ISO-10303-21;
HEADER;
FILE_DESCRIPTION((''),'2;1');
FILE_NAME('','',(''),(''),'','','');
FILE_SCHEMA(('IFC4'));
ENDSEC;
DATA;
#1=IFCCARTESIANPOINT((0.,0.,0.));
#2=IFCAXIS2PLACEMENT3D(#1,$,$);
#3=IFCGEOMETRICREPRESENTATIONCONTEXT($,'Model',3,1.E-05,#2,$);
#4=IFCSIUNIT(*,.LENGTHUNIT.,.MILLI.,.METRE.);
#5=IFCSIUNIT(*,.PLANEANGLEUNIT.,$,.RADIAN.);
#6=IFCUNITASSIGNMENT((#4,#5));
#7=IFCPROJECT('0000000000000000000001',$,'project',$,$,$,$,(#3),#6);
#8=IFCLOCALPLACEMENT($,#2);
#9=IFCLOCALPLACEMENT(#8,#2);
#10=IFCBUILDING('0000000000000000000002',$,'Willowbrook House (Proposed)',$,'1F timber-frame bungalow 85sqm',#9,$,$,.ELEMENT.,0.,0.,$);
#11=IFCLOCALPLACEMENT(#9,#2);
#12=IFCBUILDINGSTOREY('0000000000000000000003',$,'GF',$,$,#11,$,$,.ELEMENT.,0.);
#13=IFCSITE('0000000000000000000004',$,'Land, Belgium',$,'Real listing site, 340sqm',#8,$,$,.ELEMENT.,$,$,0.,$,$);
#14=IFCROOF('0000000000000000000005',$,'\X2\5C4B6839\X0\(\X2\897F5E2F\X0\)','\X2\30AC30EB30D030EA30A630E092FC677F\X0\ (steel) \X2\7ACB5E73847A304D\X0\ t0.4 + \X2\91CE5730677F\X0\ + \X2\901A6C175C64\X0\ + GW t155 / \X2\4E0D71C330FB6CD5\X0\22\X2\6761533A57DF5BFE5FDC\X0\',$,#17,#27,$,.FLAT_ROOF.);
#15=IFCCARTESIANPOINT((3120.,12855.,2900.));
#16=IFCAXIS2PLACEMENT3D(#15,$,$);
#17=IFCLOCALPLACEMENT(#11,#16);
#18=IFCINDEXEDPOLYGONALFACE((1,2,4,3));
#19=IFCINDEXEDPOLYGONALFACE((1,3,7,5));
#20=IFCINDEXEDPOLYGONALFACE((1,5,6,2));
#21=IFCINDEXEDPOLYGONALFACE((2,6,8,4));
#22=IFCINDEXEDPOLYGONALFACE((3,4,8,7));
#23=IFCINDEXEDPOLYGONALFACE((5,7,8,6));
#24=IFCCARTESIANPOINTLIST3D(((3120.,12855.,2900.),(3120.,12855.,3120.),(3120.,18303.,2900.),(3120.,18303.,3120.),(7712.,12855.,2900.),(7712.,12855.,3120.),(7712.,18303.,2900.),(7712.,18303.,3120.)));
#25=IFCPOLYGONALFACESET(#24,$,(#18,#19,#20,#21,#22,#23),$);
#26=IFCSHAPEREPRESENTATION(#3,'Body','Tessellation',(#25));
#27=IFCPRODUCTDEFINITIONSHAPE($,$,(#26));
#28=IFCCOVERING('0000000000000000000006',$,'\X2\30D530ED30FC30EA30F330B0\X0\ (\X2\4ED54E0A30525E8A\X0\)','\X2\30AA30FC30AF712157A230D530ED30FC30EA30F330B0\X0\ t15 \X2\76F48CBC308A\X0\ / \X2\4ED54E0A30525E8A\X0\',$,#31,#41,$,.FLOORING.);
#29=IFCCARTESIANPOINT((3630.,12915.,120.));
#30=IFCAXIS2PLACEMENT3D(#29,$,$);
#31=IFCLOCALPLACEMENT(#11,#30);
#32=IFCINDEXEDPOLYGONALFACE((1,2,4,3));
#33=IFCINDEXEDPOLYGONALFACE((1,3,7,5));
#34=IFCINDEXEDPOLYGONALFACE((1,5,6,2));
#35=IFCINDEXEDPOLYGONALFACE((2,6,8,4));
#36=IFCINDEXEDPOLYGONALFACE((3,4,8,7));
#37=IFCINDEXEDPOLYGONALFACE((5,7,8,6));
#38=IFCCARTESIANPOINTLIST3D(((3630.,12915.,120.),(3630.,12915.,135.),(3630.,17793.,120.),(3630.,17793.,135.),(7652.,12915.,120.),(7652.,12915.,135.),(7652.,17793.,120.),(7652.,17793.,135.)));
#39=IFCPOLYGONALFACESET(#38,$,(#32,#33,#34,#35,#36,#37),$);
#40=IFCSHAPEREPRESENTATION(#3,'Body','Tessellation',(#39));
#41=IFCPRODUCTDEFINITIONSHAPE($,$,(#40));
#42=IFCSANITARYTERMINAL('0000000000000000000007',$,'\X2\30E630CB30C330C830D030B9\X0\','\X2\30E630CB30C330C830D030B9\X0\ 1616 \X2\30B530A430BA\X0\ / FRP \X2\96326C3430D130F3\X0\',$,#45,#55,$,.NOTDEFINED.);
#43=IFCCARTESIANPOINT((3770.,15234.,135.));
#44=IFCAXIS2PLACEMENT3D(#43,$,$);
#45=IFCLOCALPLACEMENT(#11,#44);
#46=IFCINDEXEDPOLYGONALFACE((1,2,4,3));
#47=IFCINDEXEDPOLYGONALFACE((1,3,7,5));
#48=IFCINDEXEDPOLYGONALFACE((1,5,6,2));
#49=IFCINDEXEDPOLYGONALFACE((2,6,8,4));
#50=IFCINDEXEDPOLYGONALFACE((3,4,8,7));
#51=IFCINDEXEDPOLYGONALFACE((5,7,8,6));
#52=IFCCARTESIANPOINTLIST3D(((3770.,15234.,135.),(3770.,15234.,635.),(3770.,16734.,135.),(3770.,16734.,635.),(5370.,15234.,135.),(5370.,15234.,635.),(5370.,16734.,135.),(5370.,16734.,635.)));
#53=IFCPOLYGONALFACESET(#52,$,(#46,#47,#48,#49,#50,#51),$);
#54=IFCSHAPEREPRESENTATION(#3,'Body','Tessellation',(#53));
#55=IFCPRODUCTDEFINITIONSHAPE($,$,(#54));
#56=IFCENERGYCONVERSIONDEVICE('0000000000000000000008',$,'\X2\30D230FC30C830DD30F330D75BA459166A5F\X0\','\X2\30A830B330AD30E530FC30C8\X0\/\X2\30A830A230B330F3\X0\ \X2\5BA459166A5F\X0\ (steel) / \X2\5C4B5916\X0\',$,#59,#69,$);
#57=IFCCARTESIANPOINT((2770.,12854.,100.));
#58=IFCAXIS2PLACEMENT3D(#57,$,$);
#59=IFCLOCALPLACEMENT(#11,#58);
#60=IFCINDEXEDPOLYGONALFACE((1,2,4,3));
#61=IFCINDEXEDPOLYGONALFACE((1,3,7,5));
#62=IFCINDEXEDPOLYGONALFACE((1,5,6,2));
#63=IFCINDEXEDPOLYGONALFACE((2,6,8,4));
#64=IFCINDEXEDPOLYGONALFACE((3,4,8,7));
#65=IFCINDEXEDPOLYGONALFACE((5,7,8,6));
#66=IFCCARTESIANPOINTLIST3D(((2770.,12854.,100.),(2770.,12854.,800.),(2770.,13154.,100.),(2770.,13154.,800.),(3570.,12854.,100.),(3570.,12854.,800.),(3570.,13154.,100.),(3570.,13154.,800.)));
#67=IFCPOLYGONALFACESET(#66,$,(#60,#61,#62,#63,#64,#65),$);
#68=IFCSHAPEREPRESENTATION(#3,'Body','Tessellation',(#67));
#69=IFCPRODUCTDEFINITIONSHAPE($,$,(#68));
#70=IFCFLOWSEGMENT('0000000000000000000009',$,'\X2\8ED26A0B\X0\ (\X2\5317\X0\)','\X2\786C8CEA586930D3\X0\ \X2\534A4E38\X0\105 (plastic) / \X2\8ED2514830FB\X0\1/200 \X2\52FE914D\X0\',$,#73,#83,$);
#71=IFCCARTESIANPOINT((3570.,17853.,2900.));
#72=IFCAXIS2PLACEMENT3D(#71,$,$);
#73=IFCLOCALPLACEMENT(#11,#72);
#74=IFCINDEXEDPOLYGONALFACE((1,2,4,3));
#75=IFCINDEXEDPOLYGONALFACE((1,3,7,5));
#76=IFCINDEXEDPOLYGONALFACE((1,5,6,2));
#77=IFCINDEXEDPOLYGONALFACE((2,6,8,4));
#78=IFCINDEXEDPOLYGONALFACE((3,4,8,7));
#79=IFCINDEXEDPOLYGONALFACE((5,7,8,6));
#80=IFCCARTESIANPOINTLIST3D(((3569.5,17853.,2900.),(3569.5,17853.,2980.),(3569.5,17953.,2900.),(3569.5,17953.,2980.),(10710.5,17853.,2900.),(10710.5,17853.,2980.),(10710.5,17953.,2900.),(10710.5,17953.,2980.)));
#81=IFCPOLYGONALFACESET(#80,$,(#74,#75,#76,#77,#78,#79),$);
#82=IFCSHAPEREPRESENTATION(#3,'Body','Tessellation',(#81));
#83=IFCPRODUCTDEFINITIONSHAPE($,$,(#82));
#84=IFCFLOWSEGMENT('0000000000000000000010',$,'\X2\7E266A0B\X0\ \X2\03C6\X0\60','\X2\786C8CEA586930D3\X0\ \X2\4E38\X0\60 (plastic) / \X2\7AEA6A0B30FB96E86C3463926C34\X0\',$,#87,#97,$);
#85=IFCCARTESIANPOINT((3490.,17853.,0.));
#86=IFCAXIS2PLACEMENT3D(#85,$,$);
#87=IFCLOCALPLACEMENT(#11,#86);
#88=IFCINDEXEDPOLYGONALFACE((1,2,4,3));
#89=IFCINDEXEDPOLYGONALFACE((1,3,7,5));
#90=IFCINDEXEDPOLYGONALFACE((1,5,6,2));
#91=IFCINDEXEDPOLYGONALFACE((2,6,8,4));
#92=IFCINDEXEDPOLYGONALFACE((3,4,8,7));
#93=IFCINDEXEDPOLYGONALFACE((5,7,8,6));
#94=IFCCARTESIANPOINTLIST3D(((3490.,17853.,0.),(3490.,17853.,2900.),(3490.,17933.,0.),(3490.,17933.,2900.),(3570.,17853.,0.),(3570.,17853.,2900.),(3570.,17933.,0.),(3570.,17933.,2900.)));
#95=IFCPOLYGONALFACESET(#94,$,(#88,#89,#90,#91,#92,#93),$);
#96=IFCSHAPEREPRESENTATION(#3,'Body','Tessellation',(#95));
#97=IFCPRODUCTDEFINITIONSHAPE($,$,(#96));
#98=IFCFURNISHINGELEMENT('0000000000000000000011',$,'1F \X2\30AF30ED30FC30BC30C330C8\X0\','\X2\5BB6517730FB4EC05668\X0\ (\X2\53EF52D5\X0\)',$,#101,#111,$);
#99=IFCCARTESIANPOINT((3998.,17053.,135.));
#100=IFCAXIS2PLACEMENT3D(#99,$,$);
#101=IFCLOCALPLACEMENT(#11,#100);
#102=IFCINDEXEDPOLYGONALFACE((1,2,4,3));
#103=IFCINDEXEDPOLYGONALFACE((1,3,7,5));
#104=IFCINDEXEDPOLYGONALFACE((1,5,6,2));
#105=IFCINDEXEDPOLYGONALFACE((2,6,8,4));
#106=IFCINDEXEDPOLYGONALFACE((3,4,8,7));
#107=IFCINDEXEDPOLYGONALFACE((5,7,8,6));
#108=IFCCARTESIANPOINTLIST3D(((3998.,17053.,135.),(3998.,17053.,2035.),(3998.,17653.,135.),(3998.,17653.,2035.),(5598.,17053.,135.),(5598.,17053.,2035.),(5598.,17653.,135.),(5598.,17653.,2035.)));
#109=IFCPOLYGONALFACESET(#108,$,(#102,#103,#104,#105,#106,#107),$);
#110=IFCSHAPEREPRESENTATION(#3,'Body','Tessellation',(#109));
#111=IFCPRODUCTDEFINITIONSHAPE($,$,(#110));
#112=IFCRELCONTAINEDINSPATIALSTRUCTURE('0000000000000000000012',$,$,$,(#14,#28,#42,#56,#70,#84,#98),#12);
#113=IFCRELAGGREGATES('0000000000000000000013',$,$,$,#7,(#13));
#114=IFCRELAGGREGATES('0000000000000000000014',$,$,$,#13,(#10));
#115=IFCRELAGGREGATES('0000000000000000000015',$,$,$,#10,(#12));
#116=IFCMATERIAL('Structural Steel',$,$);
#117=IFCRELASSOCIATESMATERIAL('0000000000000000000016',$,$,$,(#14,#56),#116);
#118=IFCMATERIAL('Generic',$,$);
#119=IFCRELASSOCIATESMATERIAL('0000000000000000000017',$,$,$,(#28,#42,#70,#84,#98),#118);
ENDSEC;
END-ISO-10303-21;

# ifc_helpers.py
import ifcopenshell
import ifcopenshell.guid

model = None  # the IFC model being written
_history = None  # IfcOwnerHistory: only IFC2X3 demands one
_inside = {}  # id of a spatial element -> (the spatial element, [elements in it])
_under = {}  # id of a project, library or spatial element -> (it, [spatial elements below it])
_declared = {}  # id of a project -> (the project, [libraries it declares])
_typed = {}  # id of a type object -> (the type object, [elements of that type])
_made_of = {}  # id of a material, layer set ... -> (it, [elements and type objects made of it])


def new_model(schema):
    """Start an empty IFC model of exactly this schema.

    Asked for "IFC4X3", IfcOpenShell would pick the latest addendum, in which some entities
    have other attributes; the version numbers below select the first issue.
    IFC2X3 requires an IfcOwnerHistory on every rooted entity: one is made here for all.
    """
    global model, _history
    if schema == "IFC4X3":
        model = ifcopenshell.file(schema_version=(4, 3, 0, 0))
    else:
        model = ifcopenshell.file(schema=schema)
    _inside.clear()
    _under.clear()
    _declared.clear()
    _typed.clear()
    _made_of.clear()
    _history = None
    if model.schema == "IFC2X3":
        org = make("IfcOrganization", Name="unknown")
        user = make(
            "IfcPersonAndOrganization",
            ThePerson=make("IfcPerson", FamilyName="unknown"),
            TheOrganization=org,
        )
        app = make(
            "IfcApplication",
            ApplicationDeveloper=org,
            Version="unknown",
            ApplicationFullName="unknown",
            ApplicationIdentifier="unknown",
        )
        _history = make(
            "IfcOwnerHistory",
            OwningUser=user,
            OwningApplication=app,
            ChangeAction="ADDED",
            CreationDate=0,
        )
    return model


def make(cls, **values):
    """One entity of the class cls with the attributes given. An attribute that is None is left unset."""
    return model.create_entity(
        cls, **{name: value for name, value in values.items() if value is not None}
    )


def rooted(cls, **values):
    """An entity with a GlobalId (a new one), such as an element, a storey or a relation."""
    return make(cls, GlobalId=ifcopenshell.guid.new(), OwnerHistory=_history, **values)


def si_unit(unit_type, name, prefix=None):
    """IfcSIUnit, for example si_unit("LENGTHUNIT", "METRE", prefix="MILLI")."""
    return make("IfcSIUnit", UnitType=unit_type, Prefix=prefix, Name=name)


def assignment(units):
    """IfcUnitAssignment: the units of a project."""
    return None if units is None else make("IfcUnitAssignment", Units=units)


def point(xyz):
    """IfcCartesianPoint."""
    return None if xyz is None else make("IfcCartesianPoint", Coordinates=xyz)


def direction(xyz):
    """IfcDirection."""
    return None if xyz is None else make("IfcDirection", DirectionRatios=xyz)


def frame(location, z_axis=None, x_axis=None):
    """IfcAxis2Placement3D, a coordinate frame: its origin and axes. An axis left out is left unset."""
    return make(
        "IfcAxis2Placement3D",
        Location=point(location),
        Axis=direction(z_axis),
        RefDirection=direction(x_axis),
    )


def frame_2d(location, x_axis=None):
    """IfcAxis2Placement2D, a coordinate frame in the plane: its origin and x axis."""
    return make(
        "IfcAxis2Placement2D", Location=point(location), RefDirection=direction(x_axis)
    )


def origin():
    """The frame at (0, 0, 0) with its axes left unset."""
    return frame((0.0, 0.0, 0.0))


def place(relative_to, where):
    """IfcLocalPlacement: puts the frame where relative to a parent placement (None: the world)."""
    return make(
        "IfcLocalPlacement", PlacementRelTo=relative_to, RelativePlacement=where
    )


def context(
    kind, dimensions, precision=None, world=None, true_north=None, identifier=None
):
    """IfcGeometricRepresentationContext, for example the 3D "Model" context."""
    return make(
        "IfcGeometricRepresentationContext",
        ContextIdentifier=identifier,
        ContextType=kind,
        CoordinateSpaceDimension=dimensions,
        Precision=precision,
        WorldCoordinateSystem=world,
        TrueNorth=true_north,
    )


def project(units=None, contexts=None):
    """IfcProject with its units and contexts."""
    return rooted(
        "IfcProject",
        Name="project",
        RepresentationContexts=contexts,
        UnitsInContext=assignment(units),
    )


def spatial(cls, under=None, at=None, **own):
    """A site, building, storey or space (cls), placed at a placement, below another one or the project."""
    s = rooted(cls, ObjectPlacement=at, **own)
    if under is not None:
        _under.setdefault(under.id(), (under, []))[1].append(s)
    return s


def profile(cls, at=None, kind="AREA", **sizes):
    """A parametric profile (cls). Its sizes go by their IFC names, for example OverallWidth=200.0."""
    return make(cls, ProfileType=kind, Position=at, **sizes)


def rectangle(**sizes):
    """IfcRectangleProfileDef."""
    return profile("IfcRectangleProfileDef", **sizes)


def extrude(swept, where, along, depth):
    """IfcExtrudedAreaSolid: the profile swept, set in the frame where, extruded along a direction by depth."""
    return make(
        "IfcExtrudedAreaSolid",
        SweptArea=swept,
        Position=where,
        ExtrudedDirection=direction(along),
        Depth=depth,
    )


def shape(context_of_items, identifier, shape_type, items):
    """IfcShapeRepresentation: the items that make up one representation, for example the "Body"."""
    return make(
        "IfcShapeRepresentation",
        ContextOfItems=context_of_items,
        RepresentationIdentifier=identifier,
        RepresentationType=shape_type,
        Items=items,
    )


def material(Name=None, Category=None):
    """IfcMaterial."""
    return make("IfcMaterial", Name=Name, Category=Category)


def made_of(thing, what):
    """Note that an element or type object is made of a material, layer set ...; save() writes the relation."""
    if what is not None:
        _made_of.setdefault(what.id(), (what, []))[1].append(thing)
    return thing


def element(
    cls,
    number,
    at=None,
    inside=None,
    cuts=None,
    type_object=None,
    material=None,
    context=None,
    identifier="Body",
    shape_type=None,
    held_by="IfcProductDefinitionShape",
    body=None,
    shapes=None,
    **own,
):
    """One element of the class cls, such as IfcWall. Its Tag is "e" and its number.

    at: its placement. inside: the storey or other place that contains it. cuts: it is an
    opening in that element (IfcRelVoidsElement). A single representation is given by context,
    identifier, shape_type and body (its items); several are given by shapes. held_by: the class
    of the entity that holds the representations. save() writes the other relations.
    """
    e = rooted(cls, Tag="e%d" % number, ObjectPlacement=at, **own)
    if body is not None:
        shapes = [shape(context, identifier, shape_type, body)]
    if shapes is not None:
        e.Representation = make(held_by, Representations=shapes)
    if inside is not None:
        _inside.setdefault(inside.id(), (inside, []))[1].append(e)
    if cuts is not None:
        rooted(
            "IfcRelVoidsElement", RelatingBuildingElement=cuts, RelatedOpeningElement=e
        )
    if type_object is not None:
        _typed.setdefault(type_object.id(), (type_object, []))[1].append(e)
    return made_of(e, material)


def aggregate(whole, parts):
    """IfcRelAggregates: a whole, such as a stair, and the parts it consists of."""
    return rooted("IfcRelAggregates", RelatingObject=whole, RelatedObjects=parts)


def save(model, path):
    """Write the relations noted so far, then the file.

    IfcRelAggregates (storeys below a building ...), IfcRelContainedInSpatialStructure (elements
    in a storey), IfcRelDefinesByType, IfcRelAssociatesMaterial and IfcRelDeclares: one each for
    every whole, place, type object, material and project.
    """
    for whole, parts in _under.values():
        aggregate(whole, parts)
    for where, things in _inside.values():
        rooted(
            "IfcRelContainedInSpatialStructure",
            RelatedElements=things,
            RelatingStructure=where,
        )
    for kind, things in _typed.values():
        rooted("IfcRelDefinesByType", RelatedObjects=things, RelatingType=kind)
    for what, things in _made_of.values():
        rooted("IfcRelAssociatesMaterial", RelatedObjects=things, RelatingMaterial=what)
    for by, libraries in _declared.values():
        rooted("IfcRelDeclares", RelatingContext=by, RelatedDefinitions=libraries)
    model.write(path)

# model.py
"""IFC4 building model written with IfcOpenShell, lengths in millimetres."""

from ifc_helpers import new_model, si_unit, frame, frame_2d, origin, place, context, project, spatial, rectangle, extrude, material, element, save


model = new_model("IFC4")

# Units and contexts
model_context = context("Model", 3, precision=1e-05, world=origin())
ifc_project = project(units=[si_unit("LENGTHUNIT", "METRE", prefix="MILLI"), si_unit("PLANEANGLEUNIT", "RADIAN")], contexts=[model_context])

# Site, building, storey
site_placement = place(None, origin())
site = spatial("IfcSite", under=ifc_project, at=site_placement, Name="Land, Belgium", ObjectType="Real listing site, 340sqm", CompositionType="ELEMENT", RefElevation=0.0)
building_placement = place(site_placement, origin())
building = spatial("IfcBuilding", under=site, at=building_placement, Name="Willowbrook House (Proposed)", ObjectType="1F timber-frame bungalow 85sqm", CompositionType="ELEMENT", ElevationOfRefHeight=0.0, ElevationOfTerrain=0.0)
storey_placement = place(building_placement, origin())
storey = spatial("IfcBuildingStorey", under=building, at=storey_placement, Name="GF", CompositionType="ELEMENT", Elevation=0.0)

# Roof
ifc_material_1 = material(Name="Structural Steel")
roof_placement = place(storey_placement, frame((3120.0, 12855.0, 2900.0)))
element("IfcRoof", 1, at=roof_placement, inside=storey, material=ifc_material_1, Name="屋根(西帯)", Description="ガルバリウム鋼板 (steel) 立平葺き t0.4 + 野地板 + 通気層 + GW t155 / 不燃・法22条区域対応", PredefinedType="FLAT_ROOF", context=model_context, shape_type="SweptSolid", body=[
    extrude(rectangle(XDim=4592.0, YDim=5448.0, at=frame_2d((2296.0, 2724.0))), frame((3120.0, 12855.0, 2900.0)), (0.0, 0.0, 1.0), 220.0),
])

# Covering
ifc_material_2 = material(Name="Generic")
covering_placement = place(storey_placement, frame((3630.0, 12915.0, 120.0)))
element("IfcCovering", 2, at=covering_placement, inside=storey, material=ifc_material_2, Name="フローリング (仕上げ床)", Description="オーク無垢フローリング t15 直貼り / 仕上げ床", PredefinedType="FLOORING", context=model_context, shape_type="SweptSolid", body=[
    extrude(rectangle(XDim=4022.0, YDim=4878.0, at=frame_2d((2011.0, 2439.0))), frame((3630.0, 12915.0, 120.0)), (0.0, 0.0, 1.0), 15.0),
])

# Sanitary terminal
sanitary_terminal_placement = place(storey_placement, frame((3770.0, 15234.0, 135.0)))
element("IfcSanitaryTerminal", 3, at=sanitary_terminal_placement, inside=storey, material=ifc_material_2, Name="ユニットバス", Description="ユニットバス 1616 サイズ / FRP 防水パン", PredefinedType="NOTDEFINED", context=model_context, shape_type="SweptSolid", body=[
    extrude(rectangle(XDim=1600.0, YDim=1500.0, at=frame_2d((800.0, 750.0))), frame((3770.0, 15234.0, 135.0)), (0.0, 0.0, 1.0), 500.0),
])

# Energy conversion device
energy_conversion_device_placement = place(storey_placement, frame((2770.0, 12854.0, 100.0)))
element("IfcEnergyConversionDevice", 4, at=energy_conversion_device_placement, inside=storey, material=ifc_material_1, Name="ヒートポンプ室外機", Description="エコキュート/エアコン 室外機 (steel) / 屋外", context=model_context, shape_type="SweptSolid", body=[
    extrude(rectangle(XDim=800.0, YDim=300.0, at=frame_2d((400.0, 150.0))), frame((2770.0, 12854.0, 100.0)), (0.0, 0.0, 1.0), 700.0),
])

# Flow segments
flow_segment_1_placement = place(storey_placement, frame((3570.0, 17853.0, 2900.0)))
element("IfcFlowSegment", 5, at=flow_segment_1_placement, inside=storey, material=ifc_material_2, Name="軒樋 (北)", Description="硬質塩ビ 半丸105 (plastic) / 軒先・1/200 勾配", context=model_context, shape_type="SweptSolid", body=[
    extrude(rectangle(XDim=7141.0, YDim=100.0, at=frame_2d((3570.0, 50.0))), frame((3570.0, 17853.0, 2900.0)), (0.0, 0.0, 1.0), 80.0),
])
flow_segment_2_placement = place(storey_placement, frame((3490.0, 17853.0, 0.0)))
element("IfcFlowSegment", 6, at=flow_segment_2_placement, inside=storey, material=ifc_material_2, Name="縦樋 φ60", Description="硬質塩ビ 丸60 (plastic) / 竪樋・雨水排水", context=model_context, shape_type="SweptSolid", body=[
    extrude(rectangle(XDim=80.0, YDim=80.0, at=frame_2d((40.0, 40.0))), frame((3490.0, 17853.0, 0.0)), (0.0, 0.0, 1.0), 2900.0),
])

# Furnishing element
furnishing_placement = place(storey_placement, frame((3998.0, 17053.0, 135.0)))
element("IfcFurnishingElement", 7, at=furnishing_placement, inside=storey, material=ifc_material_2, Name="1F クローゼット", Description="家具・什器 (可動)", context=model_context, shape_type="SweptSolid", body=[
    extrude(rectangle(XDim=1600.0, YDim=600.0, at=frame_2d((800.0, 300.0))), frame((3998.0, 17053.0, 135.0)), (0.0, 0.0, 1.0), 1900.0),
])

save(model, "model.ifc")
